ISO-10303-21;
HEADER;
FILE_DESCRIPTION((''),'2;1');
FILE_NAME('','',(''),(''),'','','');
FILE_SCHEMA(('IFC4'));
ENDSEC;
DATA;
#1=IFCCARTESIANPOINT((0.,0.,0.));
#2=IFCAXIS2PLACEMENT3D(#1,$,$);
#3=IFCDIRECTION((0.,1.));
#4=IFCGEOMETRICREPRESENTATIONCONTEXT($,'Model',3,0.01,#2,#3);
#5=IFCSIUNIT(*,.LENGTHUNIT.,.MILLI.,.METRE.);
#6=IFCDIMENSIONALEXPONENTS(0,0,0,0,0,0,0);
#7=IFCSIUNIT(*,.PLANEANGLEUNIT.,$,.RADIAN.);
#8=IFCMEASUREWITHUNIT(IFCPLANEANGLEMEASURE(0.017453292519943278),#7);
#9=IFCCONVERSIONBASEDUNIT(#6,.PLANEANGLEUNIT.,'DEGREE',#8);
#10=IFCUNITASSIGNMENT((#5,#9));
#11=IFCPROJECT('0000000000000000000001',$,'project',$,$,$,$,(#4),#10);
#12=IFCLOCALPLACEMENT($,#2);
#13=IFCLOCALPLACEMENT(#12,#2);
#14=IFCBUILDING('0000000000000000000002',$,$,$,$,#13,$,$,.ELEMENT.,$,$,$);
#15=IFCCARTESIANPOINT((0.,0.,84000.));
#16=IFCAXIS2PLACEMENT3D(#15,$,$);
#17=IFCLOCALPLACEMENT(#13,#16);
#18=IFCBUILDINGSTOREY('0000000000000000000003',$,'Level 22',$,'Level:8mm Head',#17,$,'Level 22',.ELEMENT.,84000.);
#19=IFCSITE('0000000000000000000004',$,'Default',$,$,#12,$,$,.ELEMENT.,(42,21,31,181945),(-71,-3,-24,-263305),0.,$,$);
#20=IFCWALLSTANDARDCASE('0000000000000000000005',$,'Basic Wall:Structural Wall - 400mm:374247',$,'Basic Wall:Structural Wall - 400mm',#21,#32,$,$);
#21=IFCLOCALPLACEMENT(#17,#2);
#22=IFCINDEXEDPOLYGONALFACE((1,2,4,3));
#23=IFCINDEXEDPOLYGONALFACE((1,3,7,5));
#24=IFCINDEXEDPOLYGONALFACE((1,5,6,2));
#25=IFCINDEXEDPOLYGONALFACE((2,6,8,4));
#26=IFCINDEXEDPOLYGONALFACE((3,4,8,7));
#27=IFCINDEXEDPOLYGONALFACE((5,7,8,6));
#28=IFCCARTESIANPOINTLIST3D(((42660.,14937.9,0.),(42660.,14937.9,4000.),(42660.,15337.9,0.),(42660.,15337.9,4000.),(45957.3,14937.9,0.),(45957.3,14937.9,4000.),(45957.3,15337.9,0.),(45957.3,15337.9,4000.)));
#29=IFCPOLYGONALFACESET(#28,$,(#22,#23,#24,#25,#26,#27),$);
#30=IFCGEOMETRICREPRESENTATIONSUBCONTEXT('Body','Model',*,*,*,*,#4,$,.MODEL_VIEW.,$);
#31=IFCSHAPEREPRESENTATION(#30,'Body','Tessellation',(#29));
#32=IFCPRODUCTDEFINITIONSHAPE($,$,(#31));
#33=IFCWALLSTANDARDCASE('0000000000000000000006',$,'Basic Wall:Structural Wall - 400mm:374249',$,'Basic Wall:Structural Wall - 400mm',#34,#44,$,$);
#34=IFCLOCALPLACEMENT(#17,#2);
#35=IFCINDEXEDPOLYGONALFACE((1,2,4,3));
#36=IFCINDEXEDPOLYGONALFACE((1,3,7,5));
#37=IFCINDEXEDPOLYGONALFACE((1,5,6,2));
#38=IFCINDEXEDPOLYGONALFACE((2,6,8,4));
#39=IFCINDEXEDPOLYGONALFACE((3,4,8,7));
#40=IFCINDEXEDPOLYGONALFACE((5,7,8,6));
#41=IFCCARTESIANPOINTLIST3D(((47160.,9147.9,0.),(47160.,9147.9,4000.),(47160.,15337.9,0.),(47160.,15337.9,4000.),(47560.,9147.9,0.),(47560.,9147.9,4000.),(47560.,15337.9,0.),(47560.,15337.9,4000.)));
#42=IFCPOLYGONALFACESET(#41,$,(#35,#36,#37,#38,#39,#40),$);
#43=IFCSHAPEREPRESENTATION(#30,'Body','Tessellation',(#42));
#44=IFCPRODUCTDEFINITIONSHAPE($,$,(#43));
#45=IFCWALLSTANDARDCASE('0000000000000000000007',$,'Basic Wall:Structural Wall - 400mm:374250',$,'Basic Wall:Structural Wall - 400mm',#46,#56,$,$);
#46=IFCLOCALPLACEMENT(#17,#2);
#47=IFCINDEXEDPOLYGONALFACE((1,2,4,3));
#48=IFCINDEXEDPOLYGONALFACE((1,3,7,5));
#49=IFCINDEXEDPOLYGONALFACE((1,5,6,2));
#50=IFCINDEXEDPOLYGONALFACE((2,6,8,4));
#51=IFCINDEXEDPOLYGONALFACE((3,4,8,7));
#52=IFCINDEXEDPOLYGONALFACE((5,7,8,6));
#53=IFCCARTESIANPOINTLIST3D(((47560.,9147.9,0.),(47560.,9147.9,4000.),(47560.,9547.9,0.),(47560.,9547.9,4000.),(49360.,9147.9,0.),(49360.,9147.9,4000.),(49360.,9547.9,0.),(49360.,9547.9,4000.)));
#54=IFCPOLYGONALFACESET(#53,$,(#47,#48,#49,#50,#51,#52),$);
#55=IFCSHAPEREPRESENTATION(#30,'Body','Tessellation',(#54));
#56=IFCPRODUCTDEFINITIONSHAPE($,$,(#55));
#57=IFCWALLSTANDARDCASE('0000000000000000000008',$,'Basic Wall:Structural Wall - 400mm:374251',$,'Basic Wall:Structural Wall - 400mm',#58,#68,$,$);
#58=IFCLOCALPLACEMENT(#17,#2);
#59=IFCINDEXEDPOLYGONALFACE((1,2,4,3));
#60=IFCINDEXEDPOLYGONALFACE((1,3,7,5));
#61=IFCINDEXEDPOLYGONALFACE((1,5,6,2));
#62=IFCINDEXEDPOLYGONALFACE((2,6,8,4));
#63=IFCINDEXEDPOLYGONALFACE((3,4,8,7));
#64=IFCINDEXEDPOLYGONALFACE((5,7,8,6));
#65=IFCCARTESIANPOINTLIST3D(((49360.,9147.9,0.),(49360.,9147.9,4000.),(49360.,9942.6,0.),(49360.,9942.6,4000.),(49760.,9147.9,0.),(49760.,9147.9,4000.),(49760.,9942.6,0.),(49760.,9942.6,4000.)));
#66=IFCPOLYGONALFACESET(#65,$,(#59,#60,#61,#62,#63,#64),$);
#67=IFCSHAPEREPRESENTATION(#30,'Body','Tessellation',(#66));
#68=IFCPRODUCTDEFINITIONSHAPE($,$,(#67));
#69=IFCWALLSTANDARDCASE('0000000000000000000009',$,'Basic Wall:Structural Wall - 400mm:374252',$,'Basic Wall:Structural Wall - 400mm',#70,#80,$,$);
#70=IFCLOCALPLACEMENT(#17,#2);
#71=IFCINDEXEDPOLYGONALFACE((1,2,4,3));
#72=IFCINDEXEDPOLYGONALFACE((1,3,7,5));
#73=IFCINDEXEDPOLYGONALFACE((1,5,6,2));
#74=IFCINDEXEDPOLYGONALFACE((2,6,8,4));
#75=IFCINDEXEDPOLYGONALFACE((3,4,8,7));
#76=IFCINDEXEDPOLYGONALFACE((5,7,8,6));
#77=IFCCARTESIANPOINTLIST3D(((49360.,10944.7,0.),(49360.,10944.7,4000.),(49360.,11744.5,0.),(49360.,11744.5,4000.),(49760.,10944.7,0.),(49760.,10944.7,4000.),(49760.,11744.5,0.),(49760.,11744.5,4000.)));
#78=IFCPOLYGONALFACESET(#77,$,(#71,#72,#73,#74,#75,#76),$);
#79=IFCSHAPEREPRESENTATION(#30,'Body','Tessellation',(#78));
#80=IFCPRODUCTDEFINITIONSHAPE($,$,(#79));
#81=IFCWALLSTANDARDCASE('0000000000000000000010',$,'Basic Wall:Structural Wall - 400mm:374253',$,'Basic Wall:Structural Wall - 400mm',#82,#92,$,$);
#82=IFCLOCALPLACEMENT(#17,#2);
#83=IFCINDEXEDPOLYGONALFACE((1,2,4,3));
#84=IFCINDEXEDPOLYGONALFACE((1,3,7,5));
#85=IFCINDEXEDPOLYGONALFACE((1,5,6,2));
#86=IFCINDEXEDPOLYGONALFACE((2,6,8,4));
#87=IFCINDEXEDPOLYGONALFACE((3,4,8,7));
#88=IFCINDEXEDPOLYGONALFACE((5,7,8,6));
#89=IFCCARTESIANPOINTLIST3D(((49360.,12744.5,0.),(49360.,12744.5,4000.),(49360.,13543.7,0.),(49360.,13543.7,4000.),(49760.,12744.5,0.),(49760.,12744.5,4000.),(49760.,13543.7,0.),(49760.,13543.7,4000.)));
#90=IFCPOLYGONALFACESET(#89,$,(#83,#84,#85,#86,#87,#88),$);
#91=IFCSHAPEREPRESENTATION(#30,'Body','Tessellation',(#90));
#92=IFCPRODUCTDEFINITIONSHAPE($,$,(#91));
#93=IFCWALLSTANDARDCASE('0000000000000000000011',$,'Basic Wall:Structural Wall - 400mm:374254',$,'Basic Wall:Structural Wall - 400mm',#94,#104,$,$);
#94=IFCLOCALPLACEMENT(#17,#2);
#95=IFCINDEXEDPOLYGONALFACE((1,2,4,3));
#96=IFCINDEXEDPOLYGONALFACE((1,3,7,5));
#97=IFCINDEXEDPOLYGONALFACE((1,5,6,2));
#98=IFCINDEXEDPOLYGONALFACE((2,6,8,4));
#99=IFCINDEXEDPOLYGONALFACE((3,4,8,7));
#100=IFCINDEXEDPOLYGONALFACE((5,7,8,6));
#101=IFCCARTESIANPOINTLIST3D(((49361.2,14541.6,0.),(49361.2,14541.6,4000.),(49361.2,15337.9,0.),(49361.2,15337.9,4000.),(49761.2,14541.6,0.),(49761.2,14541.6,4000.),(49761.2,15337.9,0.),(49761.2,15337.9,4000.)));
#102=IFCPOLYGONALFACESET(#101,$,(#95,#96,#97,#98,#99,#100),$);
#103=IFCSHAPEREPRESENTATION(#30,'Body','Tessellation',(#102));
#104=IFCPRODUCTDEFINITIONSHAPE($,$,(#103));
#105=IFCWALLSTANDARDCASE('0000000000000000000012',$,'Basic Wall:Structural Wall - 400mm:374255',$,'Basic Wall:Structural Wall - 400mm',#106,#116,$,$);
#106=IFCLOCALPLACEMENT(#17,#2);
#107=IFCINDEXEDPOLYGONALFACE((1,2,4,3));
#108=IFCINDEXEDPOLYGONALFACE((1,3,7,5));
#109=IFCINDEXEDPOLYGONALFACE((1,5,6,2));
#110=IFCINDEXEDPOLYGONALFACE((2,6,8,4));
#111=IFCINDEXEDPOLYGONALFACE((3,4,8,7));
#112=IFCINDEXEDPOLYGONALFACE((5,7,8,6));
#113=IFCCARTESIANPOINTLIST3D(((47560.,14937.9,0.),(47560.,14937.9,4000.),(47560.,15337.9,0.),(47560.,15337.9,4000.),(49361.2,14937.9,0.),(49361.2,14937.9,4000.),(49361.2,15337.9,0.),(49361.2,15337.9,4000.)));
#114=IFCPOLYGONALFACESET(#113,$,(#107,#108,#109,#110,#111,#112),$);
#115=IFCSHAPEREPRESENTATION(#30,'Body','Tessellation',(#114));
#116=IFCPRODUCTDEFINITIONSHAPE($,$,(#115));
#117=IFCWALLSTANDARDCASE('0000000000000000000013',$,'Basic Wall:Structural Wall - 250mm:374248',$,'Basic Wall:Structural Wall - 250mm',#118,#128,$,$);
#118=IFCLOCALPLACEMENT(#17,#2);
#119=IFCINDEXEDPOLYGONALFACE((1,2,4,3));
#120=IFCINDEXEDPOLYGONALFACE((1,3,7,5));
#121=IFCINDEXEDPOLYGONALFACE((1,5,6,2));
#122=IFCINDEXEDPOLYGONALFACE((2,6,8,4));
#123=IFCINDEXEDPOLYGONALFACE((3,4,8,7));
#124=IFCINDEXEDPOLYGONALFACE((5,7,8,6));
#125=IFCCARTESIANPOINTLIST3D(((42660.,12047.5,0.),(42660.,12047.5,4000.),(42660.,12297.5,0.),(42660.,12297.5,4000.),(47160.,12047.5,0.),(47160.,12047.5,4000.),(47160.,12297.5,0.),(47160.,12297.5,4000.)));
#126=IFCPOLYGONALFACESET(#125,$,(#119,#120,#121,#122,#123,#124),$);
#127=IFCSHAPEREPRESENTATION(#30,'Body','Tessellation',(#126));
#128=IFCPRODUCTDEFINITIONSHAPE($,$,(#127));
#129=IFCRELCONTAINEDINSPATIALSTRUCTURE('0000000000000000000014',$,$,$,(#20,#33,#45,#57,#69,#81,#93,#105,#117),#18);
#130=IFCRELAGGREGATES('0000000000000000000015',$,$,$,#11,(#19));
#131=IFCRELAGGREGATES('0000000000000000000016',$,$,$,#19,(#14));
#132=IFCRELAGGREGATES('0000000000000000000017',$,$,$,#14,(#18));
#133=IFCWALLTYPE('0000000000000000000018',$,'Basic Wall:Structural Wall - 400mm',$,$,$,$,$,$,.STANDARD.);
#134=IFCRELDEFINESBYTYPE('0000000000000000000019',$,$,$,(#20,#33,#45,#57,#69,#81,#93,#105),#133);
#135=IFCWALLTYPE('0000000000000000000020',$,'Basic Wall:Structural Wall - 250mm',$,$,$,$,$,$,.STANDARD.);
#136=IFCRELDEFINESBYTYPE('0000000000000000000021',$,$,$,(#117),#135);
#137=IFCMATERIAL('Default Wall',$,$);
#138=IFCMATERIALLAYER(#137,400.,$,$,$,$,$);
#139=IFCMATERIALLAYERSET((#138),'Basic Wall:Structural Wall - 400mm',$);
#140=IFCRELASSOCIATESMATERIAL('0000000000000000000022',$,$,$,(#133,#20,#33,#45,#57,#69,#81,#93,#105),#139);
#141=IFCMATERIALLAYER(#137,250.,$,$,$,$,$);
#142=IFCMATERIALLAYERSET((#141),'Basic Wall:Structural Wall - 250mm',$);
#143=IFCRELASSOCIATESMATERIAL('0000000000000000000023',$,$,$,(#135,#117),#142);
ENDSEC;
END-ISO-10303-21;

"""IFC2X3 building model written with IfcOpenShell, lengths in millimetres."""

from ifc_helpers import new_model, entity, si_unit, converted_unit, direction, frame, frame_2d, origin, place, context, subcontext, project, spatial, rectangle, extrude, material, layer, layer_set, layer_usage, type_object, element, save


model = new_model("IFC2X3")

# Units and contexts
model_context = context("Model", 3, precision=0.01, world=origin(), true_north=direction((0.0, 1.0)))
body_context = subcontext(model_context, "Body", "Model", "MODEL_VIEW")
ifc_project = project(units=[si_unit("LENGTHUNIT", "METRE", prefix="MILLI"), converted_unit("PLANEANGLEUNIT", "DEGREE", entity("IfcPlaneAngleMeasure", 0.017453292519943278), si_unit("PLANEANGLEUNIT", "RADIAN"), dimensions=[0, 0, 0, 0, 0, 0, 0])], contexts=[model_context])

# Site, building, storey
site_placement = place(None, origin())
site = spatial("IfcSite", under=ifc_project, at=site_placement, Name="Default", CompositionType="ELEMENT", RefLatitude=(42, 21, 31, 181945), RefLongitude=(-71, -3, -24, -263305), RefElevation=0.0)
building_placement = place(site_placement, origin())
building = spatial("IfcBuilding", under=site, at=building_placement, CompositionType="ELEMENT")
storey_placement = place(building_placement, frame((0.0, 0.0, 84000.0)))
storey = spatial("IfcBuildingStorey", under=building, at=storey_placement, Name="Level 22", ObjectType="Level:8mm Head", LongName="Level 22", CompositionType="ELEMENT", Elevation=84000.0)

# Walls
ifc_material_1 = material(Name="Default Wall")
ifc_layer_1 = layer(ifc_material_1, 400.0)
ifc_layer_set_1 = layer_set([ifc_layer_1], Name="Basic Wall:Structural Wall - 400mm")
wall_type_1 = type_object("IfcWallType", Name="Basic Wall:Structural Wall - 400mm", PredefinedType="STANDARD", material=ifc_layer_set_1)
ifc_layer_usage_1 = layer_usage(ifc_layer_set_1, "AXIS2", "POSITIVE", -200.0)
wall_1_placement = place(storey_placement, frame((45957.3, 15137.9, 0.0), z_axis=(0.0, 0.0, 1.0), x_axis=(-1.0, 0.0, 0.0)))
element("IfcWallStandardCase", 1, at=wall_1_placement, inside=storey, type_object=wall_type_1, material=ifc_layer_usage_1, Name="Basic Wall:Structural Wall - 400mm:374247", ObjectType="Basic Wall:Structural Wall - 400mm", context=body_context, shape_type="SweptSolid", body=[
    extrude(rectangle(XDim=3297.3, YDim=400.0, at=frame_2d((1648.6, 0.0), x_axis=(-1.0, 0.0))), origin(), (0.0, 0.0, 1.0), 4000.0),
])
ifc_layer_usage_2 = layer_usage(ifc_layer_set_1, "AXIS2", "POSITIVE", -200.0)
wall_2_placement = place(storey_placement, frame((47360.0, 15337.9, 0.0), z_axis=(0.0, 0.0, 1.0), x_axis=(0.0, -1.0, 0.0)))
element("IfcWallStandardCase", 2, at=wall_2_placement, inside=storey, type_object=wall_type_1, material=ifc_layer_usage_2, Name="Basic Wall:Structural Wall - 400mm:374249", ObjectType="Basic Wall:Structural Wall - 400mm", context=body_context, shape_type="SweptSolid", body=[
    extrude(rectangle(XDim=6190.0, YDim=400.0, at=frame_2d((3095.0, 0.0), x_axis=(-1.0, 0.0))), origin(), (0.0, 0.0, 1.0), 4000.0),
])
ifc_layer_usage_3 = layer_usage(ifc_layer_set_1, "AXIS2", "POSITIVE", -200.0)
wall_3_placement = place(storey_placement, frame((47560.0, 9347.9, 0.0)))
element("IfcWallStandardCase", 3, at=wall_3_placement, inside=storey, type_object=wall_type_1, material=ifc_layer_usage_3, Name="Basic Wall:Structural Wall - 400mm:374250", ObjectType="Basic Wall:Structural Wall - 400mm", context=body_context, shape_type="SweptSolid", body=[
    extrude(rectangle(XDim=1800.0, YDim=400.0, at=frame_2d((900.0, 0.0), x_axis=(-1.0, 0.0))), origin(), (0.0, 0.0, 1.0), 4000.0),
])
ifc_layer_usage_4 = layer_usage(ifc_layer_set_1, "AXIS2", "NEGATIVE", 200.0)
wall_4_placement = place(storey_placement, frame((49560.0, 9147.9, 0.0), z_axis=(0.0, 0.0, 1.0), x_axis=(0.0, 1.0, 0.0)))
element("IfcWallStandardCase", 4, at=wall_4_placement, inside=storey, type_object=wall_type_1, material=ifc_layer_usage_4, Name="Basic Wall:Structural Wall - 400mm:374251", ObjectType="Basic Wall:Structural Wall - 400mm", context=body_context, shape_type="SweptSolid", body=[
    extrude(rectangle(XDim=794.7, YDim=400.0, at=frame_2d((397.3, 0.0), x_axis=(-1.0, 0.0))), origin(), (0.0, 0.0, 1.0), 4000.0),
])
ifc_layer_usage_5 = layer_usage(ifc_layer_set_1, "AXIS2", "POSITIVE", -200.0)
wall_5_placement = place(storey_placement, frame((49560.0, 10944.7, 0.0), z_axis=(0.0, 0.0, 1.0), x_axis=(0.0, 1.0, 0.0)))
element("IfcWallStandardCase", 5, at=wall_5_placement, inside=storey, type_object=wall_type_1, material=ifc_layer_usage_5, Name="Basic Wall:Structural Wall - 400mm:374252", ObjectType="Basic Wall:Structural Wall - 400mm", context=body_context, shape_type="SweptSolid", body=[
    extrude(rectangle(XDim=799.8, YDim=400.0, at=frame_2d((399.9, 0.0), x_axis=(-1.0, 0.0))), origin(), (0.0, 0.0, 1.0), 4000.0),
])
ifc_layer_usage_6 = layer_usage(ifc_layer_set_1, "AXIS2", "POSITIVE", -200.0)
wall_6_placement = place(storey_placement, frame((49560.0, 12744.5, 0.0), z_axis=(0.0, 0.0, 1.0), x_axis=(0.0, 1.0, 0.0)))
element("IfcWallStandardCase", 6, at=wall_6_placement, inside=storey, type_object=wall_type_1, material=ifc_layer_usage_6, Name="Basic Wall:Structural Wall - 400mm:374253", ObjectType="Basic Wall:Structural Wall - 400mm", context=body_context, shape_type="SweptSolid", body=[
    extrude(rectangle(XDim=799.2, YDim=400.0, at=frame_2d((399.6, 0.0), x_axis=(-1.0, 0.0))), origin(), (0.0, 0.0, 1.0), 4000.0),
])
ifc_layer_usage_7 = layer_usage(ifc_layer_set_1, "AXIS2", "POSITIVE", -200.0)
wall_7_placement = place(storey_placement, frame((49561.2, 14541.6, 0.0), z_axis=(0.0, 0.0, 1.0), x_axis=(0.0, 1.0, 0.0)))
element("IfcWallStandardCase", 7, at=wall_7_placement, inside=storey, type_object=wall_type_1, material=ifc_layer_usage_7, Name="Basic Wall:Structural Wall - 400mm:374254", ObjectType="Basic Wall:Structural Wall - 400mm", context=body_context, shape_type="SweptSolid", body=[
    extrude(rectangle(XDim=796.3, YDim=400.0, at=frame_2d((398.2, 0.0), x_axis=(-1.0, 0.0))), origin(), (0.0, 0.0, 1.0), 4000.0),
])
ifc_layer_usage_8 = layer_usage(ifc_layer_set_1, "AXIS2", "POSITIVE", -200.0)
wall_8_placement = place(storey_placement, frame((49361.2, 15137.9, 0.0), z_axis=(0.0, 0.0, 1.0), x_axis=(-1.0, 0.0, 0.0)))
element("IfcWallStandardCase", 8, at=wall_8_placement, inside=storey, type_object=wall_type_1, material=ifc_layer_usage_8, Name="Basic Wall:Structural Wall - 400mm:374255", ObjectType="Basic Wall:Structural Wall - 400mm", context=body_context, shape_type="SweptSolid", body=[
    extrude(rectangle(XDim=1801.2, YDim=400.0, at=frame_2d((900.6, 0.0), x_axis=(-1.0, 0.0))), origin(), (0.0, 0.0, 1.0), 4000.0),
])
ifc_layer_2 = layer(ifc_material_1, 250.0)
ifc_layer_set_2 = layer_set([ifc_layer_2], Name="Basic Wall:Structural Wall - 250mm")
ifc_layer_usage_9 = layer_usage(ifc_layer_set_2, "AXIS2", "NEGATIVE", 125.0)
wall_type_2 = type_object("IfcWallType", Name="Basic Wall:Structural Wall - 250mm", PredefinedType="STANDARD", material=ifc_layer_set_2)
wall_9_placement = place(storey_placement, frame((42660.0, 12172.5, 0.0)))
element("IfcWallStandardCase", 9, at=wall_9_placement, inside=storey, type_object=wall_type_2, material=ifc_layer_usage_9, Name="Basic Wall:Structural Wall - 250mm:374248", ObjectType="Basic Wall:Structural Wall - 250mm", context=body_context, shape_type="SweptSolid", body=[
    extrude(rectangle(XDim=4500.0, YDim=250.0, at=frame_2d((2250.0, 0.0), x_axis=(-1.0, 0.0))), origin(), (0.0, 0.0, 1.0), 4000.0),
])

save(model, "model.ifc")
